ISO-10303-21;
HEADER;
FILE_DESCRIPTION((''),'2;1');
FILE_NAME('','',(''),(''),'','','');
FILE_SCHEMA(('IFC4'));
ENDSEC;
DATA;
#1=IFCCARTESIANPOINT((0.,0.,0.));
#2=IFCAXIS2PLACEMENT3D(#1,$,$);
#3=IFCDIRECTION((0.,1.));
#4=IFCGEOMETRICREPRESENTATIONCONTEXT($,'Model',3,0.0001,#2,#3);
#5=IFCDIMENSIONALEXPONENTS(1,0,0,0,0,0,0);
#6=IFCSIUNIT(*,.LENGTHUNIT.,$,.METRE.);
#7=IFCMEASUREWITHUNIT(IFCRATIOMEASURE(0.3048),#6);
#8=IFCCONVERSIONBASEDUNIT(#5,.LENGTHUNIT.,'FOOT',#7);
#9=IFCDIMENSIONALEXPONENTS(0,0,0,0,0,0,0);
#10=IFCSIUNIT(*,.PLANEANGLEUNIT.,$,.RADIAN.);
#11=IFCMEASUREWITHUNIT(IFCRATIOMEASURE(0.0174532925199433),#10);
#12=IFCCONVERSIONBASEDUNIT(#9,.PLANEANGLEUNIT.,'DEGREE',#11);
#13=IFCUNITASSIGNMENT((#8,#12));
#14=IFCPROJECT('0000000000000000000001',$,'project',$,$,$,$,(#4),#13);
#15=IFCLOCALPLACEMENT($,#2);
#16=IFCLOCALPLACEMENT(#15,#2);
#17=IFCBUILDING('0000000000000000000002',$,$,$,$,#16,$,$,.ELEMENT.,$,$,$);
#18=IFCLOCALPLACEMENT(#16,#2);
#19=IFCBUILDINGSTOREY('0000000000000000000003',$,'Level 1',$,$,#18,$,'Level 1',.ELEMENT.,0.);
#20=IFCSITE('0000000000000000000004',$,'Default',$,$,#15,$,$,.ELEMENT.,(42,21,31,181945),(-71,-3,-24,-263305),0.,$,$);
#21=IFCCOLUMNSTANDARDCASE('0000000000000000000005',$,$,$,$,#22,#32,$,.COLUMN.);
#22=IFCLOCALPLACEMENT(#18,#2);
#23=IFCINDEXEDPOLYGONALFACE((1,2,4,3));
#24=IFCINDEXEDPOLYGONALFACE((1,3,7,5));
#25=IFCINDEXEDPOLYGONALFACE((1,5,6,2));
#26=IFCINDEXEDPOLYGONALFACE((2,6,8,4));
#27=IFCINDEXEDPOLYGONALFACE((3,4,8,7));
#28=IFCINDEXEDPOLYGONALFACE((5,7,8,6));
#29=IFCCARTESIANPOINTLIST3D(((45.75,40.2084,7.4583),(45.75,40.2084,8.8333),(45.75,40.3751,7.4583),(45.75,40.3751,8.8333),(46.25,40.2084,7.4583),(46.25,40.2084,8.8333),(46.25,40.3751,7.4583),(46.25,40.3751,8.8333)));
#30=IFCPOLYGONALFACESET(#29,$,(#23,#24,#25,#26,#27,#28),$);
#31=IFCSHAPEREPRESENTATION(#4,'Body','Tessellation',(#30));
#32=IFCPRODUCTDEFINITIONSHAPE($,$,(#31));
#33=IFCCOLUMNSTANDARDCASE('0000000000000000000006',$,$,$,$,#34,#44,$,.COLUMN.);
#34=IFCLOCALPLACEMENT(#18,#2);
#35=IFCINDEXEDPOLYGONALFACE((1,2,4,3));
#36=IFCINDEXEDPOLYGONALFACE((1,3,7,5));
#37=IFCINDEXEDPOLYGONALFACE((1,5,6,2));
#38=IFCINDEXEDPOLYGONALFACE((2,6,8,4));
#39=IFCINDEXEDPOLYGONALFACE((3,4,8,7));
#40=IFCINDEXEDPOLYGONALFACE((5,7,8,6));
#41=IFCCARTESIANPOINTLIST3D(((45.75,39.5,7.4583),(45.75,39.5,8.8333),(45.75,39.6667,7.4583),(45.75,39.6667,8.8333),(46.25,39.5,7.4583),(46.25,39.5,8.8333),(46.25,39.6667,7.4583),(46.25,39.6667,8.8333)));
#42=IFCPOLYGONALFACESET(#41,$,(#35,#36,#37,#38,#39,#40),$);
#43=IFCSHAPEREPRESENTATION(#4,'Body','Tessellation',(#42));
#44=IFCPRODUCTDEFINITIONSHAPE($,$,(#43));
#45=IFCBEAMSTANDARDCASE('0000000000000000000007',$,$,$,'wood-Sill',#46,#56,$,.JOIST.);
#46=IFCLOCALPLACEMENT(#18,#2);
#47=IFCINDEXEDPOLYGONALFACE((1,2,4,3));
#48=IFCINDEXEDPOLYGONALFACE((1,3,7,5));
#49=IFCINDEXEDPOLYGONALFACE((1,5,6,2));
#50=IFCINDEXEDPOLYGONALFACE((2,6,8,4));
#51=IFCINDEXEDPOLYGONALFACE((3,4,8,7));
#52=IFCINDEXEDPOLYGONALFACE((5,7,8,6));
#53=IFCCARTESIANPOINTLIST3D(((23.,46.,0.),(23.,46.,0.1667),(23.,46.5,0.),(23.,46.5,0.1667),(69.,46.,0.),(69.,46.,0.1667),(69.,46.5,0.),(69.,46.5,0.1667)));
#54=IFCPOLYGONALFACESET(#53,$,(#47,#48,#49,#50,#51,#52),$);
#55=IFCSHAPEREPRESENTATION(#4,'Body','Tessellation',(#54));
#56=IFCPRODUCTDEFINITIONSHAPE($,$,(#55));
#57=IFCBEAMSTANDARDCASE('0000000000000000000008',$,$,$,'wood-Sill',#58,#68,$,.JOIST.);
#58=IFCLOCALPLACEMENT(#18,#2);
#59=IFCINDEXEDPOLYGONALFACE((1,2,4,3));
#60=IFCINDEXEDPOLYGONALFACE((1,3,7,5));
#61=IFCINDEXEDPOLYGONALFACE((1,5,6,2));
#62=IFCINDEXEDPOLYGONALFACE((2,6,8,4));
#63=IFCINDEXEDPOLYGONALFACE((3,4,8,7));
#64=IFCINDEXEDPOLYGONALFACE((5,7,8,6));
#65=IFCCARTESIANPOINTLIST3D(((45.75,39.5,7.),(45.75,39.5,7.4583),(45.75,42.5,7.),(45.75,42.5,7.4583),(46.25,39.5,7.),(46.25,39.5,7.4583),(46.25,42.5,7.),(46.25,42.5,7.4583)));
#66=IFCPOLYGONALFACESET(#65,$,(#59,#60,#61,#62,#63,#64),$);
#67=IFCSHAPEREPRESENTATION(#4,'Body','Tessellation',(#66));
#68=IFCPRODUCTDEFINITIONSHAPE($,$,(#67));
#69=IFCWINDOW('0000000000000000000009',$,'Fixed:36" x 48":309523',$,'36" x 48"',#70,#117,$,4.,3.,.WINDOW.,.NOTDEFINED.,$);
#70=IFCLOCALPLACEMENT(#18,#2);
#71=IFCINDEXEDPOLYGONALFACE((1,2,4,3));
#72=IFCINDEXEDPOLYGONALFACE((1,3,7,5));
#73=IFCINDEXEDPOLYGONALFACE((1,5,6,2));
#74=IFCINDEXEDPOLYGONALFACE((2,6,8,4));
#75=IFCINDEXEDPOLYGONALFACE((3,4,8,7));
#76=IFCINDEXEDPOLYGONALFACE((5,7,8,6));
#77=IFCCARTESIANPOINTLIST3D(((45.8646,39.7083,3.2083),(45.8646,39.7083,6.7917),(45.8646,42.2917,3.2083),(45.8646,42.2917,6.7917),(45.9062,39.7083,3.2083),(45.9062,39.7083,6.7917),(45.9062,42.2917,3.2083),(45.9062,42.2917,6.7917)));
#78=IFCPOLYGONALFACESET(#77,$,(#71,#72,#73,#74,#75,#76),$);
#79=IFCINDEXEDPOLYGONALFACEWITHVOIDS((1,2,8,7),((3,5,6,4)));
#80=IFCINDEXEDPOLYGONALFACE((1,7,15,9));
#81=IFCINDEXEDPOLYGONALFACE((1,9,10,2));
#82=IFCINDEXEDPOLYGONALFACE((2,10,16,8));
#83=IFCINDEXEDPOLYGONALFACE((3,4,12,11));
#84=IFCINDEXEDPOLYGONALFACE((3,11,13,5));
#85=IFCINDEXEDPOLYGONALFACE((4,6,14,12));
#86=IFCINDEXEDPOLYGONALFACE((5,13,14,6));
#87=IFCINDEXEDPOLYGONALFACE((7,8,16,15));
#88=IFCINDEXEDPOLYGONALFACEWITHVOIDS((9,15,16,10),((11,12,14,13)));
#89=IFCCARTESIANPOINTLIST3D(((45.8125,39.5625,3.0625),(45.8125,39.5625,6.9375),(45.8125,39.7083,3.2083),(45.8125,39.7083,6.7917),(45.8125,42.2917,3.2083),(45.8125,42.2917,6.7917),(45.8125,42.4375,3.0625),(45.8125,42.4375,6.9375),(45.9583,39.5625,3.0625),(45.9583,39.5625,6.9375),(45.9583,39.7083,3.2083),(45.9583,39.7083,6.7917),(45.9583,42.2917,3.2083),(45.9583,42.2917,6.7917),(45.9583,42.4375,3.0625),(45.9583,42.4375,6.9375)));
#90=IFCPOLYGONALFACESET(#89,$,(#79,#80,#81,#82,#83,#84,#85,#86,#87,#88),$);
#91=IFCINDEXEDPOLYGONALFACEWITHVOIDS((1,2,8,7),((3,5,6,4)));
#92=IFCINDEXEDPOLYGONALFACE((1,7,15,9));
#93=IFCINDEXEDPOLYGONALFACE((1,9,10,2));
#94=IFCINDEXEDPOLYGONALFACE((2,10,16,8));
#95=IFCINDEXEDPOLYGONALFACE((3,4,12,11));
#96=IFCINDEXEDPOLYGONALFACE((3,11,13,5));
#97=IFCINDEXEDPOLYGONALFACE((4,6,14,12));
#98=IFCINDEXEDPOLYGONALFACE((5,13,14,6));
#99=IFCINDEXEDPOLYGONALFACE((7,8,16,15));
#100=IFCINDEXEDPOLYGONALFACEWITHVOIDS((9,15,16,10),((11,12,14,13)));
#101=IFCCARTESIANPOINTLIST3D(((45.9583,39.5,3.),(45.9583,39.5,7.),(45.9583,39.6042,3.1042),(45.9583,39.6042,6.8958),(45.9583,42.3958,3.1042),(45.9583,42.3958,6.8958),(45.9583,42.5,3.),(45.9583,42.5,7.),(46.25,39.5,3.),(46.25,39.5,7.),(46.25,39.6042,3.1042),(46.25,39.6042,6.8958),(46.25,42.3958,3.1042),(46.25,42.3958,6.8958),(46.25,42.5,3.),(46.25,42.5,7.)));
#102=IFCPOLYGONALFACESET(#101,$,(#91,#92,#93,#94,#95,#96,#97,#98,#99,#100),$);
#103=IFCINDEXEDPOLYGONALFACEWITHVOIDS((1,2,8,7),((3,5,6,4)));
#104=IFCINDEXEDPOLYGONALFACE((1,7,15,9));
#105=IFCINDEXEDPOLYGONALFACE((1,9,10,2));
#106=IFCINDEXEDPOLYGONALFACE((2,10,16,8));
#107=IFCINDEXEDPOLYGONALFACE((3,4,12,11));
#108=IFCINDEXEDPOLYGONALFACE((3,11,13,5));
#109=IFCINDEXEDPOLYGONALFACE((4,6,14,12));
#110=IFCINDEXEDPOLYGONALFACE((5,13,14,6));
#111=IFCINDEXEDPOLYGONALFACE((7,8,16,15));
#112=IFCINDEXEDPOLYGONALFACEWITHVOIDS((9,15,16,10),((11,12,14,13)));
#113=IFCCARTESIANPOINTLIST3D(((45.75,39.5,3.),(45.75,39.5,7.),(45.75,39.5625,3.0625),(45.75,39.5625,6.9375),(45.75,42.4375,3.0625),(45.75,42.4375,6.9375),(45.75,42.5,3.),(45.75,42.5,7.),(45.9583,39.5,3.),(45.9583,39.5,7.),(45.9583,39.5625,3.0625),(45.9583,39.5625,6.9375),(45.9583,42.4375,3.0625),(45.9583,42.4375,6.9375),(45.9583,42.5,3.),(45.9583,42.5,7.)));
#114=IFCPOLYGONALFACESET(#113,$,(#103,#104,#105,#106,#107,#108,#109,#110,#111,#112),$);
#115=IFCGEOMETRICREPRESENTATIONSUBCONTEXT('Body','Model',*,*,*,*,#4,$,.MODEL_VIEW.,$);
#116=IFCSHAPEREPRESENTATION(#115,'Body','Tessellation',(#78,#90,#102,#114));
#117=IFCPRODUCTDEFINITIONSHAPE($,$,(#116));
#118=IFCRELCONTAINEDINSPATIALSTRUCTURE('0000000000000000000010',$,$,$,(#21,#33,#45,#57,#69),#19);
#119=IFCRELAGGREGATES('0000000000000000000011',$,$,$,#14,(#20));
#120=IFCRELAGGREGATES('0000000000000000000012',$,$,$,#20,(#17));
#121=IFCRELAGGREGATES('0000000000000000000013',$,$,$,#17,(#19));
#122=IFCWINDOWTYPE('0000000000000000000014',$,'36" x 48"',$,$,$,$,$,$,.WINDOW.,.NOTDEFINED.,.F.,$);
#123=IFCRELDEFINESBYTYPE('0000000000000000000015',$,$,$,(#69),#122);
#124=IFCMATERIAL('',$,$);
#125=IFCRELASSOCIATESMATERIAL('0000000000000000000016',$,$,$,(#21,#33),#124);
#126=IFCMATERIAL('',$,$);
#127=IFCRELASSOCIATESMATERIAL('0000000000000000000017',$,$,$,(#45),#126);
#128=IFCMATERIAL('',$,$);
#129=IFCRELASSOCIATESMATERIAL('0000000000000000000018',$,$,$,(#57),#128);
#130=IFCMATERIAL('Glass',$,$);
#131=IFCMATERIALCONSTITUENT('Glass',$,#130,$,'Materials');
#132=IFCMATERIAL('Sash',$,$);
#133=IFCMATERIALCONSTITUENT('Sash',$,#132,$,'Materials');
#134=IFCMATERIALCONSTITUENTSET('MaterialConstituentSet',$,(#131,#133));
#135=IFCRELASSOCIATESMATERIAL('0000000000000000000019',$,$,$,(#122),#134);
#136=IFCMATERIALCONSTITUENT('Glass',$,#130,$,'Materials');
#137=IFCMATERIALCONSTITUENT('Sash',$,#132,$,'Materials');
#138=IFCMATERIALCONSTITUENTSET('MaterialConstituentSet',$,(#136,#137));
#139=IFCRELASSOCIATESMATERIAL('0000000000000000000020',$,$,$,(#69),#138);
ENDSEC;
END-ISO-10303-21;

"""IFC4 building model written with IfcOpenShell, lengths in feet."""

from ifc_helpers import new_model, entity, si_unit, converted_unit, direction, frame, frame_2d, origin, place, context, subcontext, project, spatial, polyline, rectangle, outline, extrude, source, transform, mapped, material, constituent, constituent_set, type_object, type_shapes, element, save


model = new_model("IFC4")

# Units and contexts
model_context = context("Model", 3, precision=0.0001, world=origin(), true_north=direction((0.0, 1.0)))
body_context = subcontext(model_context, "Body", "Model", "MODEL_VIEW")
ifc_project = project(units=[converted_unit("LENGTHUNIT", "FOOT", entity("IfcRatioMeasure", 0.3048), si_unit("LENGTHUNIT", "METRE"), dimensions=[1, 0, 0, 0, 0, 0, 0]), converted_unit("PLANEANGLEUNIT", "DEGREE", entity("IfcRatioMeasure", 0.0174532925199433), si_unit("PLANEANGLEUNIT", "RADIAN"), dimensions=[0, 0, 0, 0, 0, 0, 0])], contexts=[model_context])

# Site, building, storey
site_placement = place(None, origin())
site = spatial("IfcSite", under=ifc_project, at=site_placement, Name="Default", CompositionType="ELEMENT", RefLatitude=(42, 21, 31, 181945), RefLongitude=(-71, -3, -24, -263305), RefElevation=0.0)
building_placement = place(site_placement, origin())
building = spatial("IfcBuilding", under=site, at=building_placement, CompositionType="ELEMENT")
storey_placement = place(building_placement, origin())
storey = spatial("IfcBuildingStorey", under=building, at=storey_placement, Name="Level 1", LongName="Level 1", CompositionType="ELEMENT", Elevation=0.0)

# Columns
placement_1 = place(storey_placement, frame((46.0, 46.25, 0.0), z_axis=(0.0, 0.0, 1.0), x_axis=(0.0, -1.0, 0.0)))
ifc_material_1 = material(Name="")
for number, where, z_axis, x_axis in (
    (1, (5.9583, 0.0, 7.4583), (0.0, 0.0, 1.0), (1.0, 0.0, 0.0)),
    (2, (6.6667, 0.0, 7.4583), (0.0, 0.0, 1.0), (1.0, 0.0, 0.0)),
):
    element("IfcColumnStandardCase", number, at=place(placement_1, frame(where, z_axis=z_axis, x_axis=x_axis)), inside=storey, material=ifc_material_1, PredefinedType="COLUMN", context=model_context, shape_type="SweptSolid", body=[
        extrude(rectangle(XDim=0.1667, YDim=0.5), origin(), (0.0, 0.0, 1.0), 1.375),
    ])

# Beams
ifc_material_2 = material(Name="")
beam_1_placement = place(placement_1, frame((0.0, 0.0, 0.0), z_axis=(0.0, 0.0, 1.0), x_axis=(0.0, -1.0, 0.0)))
element("IfcBeamStandardCase", 3, at=beam_1_placement, inside=storey, material=ifc_material_2, ObjectType="wood-Sill", PredefinedType="JOIST", context=model_context, shape_type="SweptSolid", body=[
    extrude(rectangle(XDim=46.0, YDim=0.5), origin(), (0.0, 0.0, 1.0), 0.1667),
])
ifc_material_3 = material(Name="")
beam_2_placement = place(placement_1, frame((5.25, 0.0, 7.0), z_axis=(0.0, 0.0, 1.0), x_axis=(-1.0, 0.0, 0.0)))
element("IfcBeamStandardCase", 4, at=beam_2_placement, inside=storey, material=ifc_material_3, ObjectType="wood-Sill", PredefinedType="JOIST", context=model_context, shape_type="SweptSolid", body=[
    extrude(rectangle(XDim=3.0, YDim=0.5), origin(), (0.0, 0.0, 1.0), 0.4583),
])

# Window
ifc_material_4 = material(Name="Glass")
ifc_constituent_1 = constituent(ifc_material_4, Name="Glass", Category="Materials")
ifc_material_5 = material(Name="Sash")
ifc_constituent_2 = constituent(ifc_material_5, Name="Sash", Category="Materials")
ifc_constituent_set_1 = constituent_set(constituents=[ifc_constituent_1, ifc_constituent_2], Name="MaterialConstituentSet")
ifc_constituent_3 = constituent(ifc_material_4, Name="Glass", Category="Materials")
ifc_constituent_4 = constituent(ifc_material_5, Name="Sash", Category="Materials")
ifc_constituent_set_2 = constituent_set(constituents=[ifc_constituent_3, ifc_constituent_4], Name="MaterialConstituentSet")
window_type = type_object("IfcWindowType", Name="36\" x 48\"", ParameterTakesPrecedence=False, PartitioningType="NOTDEFINED", PredefinedType="WINDOW", material=ifc_constituent_set_2)
shared_shape = source(origin(), body_context, "Body", "SweptSolid", [
    extrude(rectangle(XDim=0.0417, YDim=2.5833, at=frame_2d((0.0, 0.0), x_axis=(1.0, 0.0))), frame((1.5, 0.3646, 0.2083), z_axis=(0.0, 0.0, 1.0), x_axis=(0.0, 1.0, 0.0)), (0.0, 0.0, 1.0), 3.5833),
    extrude(outline(polyline([(-1.4375, -1.9375), (1.4375, -1.9375), (1.4375, 1.9375), (-1.4375, 1.9375), (-1.4375, -1.9375)]), holes=[polyline([(-1.2917, -1.7917), (-1.2917, 1.7917), (1.2917, 1.7917), (1.2917, -1.7917), (-1.2917, -1.7917)])]), frame((1.5, 0.2917, 2.0), z_axis=(0.0, 1.0, 0.0), x_axis=(1.0, 0.0, 0.0)), (0.0, 0.0, 1.0), 0.1458),
    extrude(outline(polyline([(-1.5, -2.0), (1.5, -2.0), (1.5, 2.0), (-1.5, 2.0), (-1.5, -2.0)]), holes=[polyline([(-1.3958, -1.8958), (-1.3958, 1.8958), (1.3958, 1.8958), (1.3958, -1.8958), (-1.3958, -1.8958)])]), frame((1.5, 0.0, 2.0), z_axis=(0.0, 1.0, 0.0), x_axis=(1.0, 0.0, 0.0)), (0.0, 0.0, 1.0), 0.2917),
    extrude(outline(polyline([(-2.0, -1.5), (2.0, -1.5), (2.0, 1.5), (-2.0, 1.5), (-2.0, -1.5)]), holes=[polyline([(-1.9375, -1.4375), (-1.9375, 1.4375), (1.9375, 1.4375), (1.9375, -1.4375), (-1.9375, -1.4375)])]), frame((1.5, 0.2917, 2.0), z_axis=(0.0, 1.0, 0.0), x_axis=(0.0, 0.0, -1.0)), (0.0, 0.0, 1.0), 0.2083),
])
type_shapes(window_type, [shared_shape])
placement_2 = place(placement_1, frame((6.75, 0.25, 3.0)))
window_placement = place(placement_2, frame((0.0, 0.0, 0.0), z_axis=(0.0, 0.0, 1.0), x_axis=(-1.0, 0.0, 0.0)))
element("IfcWindow", 5, at=window_placement, inside=storey, type_object=window_type, material=ifc_constituent_set_1, Name="Fixed:36\" x 48\":309523", ObjectType="36\" x 48\"", OverallHeight=4.0, OverallWidth=3.0, PartitioningType="NOTDEFINED", PredefinedType="WINDOW", context=body_context, shape_type="MappedRepresentation", body=[
    mapped(shared_shape, transform((0.0, 0.0, 0.0), scale=1.0)),
])

save(model, "model.ifc")
